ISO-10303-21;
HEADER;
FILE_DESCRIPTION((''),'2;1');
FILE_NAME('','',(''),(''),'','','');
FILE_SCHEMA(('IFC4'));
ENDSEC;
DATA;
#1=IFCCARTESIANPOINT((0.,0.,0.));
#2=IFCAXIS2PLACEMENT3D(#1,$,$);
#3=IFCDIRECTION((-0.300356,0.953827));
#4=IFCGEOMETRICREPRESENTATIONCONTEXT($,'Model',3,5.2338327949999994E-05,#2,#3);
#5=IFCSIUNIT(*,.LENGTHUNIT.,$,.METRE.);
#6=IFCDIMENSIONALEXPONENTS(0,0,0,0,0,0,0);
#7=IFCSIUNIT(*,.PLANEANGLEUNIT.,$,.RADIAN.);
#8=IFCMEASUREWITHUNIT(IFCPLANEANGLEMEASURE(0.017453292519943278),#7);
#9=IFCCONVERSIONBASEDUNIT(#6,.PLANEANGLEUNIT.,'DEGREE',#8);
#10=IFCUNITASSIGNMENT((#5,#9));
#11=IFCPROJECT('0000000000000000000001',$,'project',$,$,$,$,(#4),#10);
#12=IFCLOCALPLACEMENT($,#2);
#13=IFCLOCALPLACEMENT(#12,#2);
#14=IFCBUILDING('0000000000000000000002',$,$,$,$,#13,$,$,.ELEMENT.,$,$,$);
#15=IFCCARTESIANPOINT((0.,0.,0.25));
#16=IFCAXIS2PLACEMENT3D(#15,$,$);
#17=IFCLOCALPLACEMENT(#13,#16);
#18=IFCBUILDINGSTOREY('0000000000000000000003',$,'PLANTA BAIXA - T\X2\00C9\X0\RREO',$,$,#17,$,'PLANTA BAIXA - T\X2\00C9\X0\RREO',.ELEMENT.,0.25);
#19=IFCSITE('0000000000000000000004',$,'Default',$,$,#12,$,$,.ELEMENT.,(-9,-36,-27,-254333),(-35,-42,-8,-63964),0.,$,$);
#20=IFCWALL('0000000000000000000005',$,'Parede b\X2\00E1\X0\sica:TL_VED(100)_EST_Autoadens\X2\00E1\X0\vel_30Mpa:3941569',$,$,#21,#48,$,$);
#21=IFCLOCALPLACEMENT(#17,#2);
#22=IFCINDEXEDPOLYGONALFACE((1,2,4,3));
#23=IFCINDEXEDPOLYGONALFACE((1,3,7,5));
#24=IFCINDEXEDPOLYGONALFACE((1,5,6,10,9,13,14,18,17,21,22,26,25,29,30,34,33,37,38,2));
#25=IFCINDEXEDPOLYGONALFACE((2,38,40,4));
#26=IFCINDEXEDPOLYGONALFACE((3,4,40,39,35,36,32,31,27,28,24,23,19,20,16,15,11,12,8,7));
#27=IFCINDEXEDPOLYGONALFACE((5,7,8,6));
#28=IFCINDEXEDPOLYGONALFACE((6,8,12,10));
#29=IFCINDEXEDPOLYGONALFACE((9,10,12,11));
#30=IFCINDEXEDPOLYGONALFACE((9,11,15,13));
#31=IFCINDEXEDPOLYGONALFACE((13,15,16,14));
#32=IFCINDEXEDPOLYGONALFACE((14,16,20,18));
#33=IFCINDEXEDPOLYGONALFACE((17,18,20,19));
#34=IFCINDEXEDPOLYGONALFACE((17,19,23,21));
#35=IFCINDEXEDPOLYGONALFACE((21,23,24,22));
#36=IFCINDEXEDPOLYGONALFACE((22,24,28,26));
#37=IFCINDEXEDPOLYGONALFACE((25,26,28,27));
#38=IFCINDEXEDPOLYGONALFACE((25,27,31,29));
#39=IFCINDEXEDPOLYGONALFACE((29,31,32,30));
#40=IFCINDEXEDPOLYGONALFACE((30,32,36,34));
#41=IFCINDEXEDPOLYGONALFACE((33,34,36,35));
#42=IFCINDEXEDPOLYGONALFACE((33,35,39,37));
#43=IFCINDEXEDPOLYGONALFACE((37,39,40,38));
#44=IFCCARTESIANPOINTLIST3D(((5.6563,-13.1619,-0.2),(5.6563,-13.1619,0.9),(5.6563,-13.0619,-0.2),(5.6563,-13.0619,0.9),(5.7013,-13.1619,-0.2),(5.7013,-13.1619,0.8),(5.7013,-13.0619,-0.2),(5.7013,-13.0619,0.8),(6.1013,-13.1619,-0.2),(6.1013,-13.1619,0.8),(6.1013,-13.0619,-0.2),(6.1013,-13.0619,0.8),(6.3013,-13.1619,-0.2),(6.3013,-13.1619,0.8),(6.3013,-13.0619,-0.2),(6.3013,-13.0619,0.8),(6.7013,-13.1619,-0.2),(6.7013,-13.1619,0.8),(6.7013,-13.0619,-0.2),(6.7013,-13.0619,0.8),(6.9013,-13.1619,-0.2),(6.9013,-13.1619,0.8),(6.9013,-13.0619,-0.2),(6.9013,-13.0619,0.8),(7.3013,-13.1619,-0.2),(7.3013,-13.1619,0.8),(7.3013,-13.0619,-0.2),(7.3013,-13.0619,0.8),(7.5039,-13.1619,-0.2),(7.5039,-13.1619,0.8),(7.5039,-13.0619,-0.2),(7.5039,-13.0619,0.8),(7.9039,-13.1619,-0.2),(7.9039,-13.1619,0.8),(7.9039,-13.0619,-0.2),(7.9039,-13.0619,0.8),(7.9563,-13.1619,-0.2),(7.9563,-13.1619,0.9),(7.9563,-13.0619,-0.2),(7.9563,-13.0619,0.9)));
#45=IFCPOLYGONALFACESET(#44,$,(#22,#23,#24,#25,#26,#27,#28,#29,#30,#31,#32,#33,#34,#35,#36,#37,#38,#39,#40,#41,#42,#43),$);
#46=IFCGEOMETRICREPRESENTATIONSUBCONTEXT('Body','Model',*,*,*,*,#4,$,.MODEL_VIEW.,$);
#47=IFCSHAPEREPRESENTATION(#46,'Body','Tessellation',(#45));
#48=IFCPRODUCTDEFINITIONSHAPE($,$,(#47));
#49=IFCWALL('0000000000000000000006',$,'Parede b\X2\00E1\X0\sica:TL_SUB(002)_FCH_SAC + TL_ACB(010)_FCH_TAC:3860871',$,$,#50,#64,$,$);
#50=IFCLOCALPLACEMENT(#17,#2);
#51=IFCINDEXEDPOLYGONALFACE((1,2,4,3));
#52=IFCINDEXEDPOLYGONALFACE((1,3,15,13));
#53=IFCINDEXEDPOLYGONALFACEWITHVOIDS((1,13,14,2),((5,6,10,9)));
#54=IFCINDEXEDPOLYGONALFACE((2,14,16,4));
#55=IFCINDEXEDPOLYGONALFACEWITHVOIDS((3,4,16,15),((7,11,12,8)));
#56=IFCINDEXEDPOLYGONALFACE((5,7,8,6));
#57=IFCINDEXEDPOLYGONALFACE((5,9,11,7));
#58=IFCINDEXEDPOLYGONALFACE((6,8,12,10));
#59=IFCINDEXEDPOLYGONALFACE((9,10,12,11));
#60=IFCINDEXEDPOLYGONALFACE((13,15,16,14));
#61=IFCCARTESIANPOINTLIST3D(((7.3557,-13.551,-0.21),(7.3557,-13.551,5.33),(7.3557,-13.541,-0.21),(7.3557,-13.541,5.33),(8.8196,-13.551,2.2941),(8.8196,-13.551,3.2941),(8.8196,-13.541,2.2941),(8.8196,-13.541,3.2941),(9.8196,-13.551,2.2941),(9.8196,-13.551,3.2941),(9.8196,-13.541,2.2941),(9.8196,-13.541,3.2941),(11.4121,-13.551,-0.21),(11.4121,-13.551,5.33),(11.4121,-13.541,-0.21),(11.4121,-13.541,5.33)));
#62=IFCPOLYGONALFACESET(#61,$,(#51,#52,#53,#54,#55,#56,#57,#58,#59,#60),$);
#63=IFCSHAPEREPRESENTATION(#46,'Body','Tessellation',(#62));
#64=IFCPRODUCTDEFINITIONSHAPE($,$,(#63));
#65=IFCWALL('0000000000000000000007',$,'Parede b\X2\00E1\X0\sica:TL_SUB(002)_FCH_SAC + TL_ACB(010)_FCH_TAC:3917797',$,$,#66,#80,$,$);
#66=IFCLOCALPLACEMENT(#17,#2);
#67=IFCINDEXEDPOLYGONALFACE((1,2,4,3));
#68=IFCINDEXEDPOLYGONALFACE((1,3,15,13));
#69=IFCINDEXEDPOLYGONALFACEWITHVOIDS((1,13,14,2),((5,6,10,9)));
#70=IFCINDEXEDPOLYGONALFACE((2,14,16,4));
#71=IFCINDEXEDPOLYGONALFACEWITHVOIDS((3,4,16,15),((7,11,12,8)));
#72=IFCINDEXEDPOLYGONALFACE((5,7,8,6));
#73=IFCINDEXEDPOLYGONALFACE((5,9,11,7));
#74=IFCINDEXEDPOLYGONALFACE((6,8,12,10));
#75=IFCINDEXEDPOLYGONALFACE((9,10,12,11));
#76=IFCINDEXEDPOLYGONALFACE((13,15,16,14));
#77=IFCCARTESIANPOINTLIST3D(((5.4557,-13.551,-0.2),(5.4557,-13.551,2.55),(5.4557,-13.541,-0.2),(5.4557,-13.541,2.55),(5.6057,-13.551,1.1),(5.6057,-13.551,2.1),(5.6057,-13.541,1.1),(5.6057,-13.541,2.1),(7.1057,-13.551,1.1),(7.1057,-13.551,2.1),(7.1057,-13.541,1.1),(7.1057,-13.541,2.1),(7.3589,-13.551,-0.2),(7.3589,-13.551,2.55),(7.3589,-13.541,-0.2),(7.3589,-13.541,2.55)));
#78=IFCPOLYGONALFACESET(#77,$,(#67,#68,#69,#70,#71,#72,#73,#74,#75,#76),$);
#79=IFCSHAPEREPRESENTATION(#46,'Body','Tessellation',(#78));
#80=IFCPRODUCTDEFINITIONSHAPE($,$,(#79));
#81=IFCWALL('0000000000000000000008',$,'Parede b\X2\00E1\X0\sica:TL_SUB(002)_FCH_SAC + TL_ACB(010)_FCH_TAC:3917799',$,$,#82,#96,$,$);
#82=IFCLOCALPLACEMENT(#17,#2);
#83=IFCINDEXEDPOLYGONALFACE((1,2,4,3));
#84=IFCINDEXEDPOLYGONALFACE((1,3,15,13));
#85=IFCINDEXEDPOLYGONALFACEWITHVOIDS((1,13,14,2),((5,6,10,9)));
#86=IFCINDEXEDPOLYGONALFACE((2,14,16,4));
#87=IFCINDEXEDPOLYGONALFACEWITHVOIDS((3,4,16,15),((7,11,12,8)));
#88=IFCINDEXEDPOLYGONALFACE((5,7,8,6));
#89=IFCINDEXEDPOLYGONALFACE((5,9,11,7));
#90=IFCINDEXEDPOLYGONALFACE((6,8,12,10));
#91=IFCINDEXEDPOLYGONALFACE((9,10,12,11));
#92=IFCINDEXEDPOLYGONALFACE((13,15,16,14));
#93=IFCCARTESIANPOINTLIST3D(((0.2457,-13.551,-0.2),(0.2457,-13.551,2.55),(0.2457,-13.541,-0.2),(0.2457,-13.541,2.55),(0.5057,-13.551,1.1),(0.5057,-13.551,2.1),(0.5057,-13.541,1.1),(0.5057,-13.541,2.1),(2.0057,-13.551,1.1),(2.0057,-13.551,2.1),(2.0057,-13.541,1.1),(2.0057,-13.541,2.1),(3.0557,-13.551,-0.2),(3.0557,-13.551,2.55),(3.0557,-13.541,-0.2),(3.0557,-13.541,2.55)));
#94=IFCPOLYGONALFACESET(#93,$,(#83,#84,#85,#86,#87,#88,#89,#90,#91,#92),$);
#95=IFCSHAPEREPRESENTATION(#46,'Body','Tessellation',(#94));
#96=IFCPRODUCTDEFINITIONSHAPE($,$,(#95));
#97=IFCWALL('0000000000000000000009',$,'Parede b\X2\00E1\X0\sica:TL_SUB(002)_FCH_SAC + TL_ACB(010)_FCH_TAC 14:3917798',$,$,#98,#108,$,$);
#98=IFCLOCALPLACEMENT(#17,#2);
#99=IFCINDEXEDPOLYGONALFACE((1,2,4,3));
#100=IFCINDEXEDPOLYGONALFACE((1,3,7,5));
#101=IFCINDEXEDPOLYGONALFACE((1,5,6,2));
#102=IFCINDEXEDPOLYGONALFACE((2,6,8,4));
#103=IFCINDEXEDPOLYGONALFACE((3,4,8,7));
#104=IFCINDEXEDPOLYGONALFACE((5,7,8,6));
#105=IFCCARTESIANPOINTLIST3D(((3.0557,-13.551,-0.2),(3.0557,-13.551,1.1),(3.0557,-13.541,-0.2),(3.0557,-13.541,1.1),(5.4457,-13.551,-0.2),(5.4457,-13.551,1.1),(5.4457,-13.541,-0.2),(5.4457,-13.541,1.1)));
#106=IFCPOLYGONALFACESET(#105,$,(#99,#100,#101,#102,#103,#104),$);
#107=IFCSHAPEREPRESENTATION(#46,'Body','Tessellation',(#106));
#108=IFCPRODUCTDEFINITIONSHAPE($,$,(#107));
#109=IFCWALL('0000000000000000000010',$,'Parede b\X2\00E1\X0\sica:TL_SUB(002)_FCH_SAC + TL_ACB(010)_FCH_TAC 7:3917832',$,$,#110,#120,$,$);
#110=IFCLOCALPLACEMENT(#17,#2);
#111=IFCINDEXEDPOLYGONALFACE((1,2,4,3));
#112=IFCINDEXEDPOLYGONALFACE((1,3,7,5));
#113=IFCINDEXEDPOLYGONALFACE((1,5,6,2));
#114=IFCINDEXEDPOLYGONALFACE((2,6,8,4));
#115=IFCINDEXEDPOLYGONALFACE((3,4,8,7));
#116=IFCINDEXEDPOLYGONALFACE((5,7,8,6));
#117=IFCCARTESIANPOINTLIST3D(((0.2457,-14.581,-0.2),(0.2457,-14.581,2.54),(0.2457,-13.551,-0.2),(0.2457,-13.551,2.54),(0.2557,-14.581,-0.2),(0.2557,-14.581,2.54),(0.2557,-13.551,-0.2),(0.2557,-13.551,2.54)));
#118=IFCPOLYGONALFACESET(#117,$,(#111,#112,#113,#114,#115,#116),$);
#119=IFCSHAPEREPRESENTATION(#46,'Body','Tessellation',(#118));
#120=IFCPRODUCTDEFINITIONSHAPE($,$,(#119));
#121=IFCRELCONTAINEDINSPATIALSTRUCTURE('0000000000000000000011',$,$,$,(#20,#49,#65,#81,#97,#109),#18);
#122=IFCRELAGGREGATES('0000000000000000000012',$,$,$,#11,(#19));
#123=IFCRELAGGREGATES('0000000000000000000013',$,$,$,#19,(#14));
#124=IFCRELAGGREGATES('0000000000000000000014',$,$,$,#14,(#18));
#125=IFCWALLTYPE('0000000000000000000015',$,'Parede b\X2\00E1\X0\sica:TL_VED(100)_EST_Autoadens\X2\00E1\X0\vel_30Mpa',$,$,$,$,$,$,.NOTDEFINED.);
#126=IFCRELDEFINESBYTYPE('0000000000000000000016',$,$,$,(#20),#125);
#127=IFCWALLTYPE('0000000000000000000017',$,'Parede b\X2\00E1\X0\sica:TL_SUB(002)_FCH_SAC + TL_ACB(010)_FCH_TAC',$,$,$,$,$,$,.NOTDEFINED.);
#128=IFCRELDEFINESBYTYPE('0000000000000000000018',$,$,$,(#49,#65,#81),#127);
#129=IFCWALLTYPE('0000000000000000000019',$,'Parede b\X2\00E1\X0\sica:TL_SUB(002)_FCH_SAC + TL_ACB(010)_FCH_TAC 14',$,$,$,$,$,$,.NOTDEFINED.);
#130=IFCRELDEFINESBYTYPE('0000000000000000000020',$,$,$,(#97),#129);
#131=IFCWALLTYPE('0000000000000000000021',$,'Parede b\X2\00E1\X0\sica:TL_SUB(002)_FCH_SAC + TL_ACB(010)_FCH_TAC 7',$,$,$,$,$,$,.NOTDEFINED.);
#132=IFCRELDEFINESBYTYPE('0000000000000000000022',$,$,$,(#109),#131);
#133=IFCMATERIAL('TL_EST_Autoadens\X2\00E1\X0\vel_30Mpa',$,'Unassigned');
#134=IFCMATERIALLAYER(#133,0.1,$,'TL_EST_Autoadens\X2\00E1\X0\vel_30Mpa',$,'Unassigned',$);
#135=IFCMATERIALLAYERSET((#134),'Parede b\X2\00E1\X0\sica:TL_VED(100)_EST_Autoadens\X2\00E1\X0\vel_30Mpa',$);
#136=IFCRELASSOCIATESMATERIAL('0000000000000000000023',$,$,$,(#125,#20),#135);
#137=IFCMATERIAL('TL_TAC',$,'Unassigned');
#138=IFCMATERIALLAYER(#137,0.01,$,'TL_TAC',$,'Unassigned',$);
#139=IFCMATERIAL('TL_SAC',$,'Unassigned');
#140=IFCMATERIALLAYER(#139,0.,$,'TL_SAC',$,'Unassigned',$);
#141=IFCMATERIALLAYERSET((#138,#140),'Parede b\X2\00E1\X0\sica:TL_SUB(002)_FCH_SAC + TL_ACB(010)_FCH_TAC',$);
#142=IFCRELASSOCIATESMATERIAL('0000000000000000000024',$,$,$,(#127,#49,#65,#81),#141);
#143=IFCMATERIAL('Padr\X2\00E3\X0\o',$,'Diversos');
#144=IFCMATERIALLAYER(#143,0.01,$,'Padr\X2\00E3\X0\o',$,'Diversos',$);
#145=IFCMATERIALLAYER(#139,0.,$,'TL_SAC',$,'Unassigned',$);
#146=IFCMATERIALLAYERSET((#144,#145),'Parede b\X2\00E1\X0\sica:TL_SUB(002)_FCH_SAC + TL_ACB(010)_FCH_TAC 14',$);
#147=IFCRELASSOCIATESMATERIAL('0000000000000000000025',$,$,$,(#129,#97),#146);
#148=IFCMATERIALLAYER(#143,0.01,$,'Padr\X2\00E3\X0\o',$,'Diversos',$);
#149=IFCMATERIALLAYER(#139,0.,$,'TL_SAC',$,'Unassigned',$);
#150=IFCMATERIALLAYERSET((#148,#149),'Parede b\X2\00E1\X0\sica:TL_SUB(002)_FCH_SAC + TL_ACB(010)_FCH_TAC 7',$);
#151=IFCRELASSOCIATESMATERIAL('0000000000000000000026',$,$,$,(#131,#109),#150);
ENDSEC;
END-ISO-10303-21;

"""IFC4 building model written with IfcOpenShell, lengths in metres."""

from ifc_helpers import new_model, entity, si_unit, converted_unit, direction, frame, frame_2d, origin, place, context, subcontext, project, spatial, polyline, rectangle, extrude, clip, bounded_halfspace, material, layer, layer_set, layer_usage, type_object, element, save


model = new_model("IFC4")

# Units and contexts
model_context = context("Model", 3, precision=5.2338327949999994e-05, world=origin(), true_north=direction((-0.300356, 0.953827)))
body_context = subcontext(model_context, "Body", "Model", "MODEL_VIEW")
ifc_project = project(units=[si_unit("LENGTHUNIT", "METRE"), converted_unit("PLANEANGLEUNIT", "DEGREE", entity("IfcPlaneAngleMeasure", 0.017453292519943278), si_unit("PLANEANGLEUNIT", "RADIAN"), dimensions=[0, 0, 0, 0, 0, 0, 0])], contexts=[model_context])

# Site, building, storey
site_placement = place(None, origin())
site = spatial("IfcSite", under=ifc_project, at=site_placement, Name="Default", CompositionType="ELEMENT", RefLatitude=(-9, -36, -27, -254333), RefLongitude=(-35, -42, -8, -63964), RefElevation=0.0)
building_placement = place(site_placement, origin())
building = spatial("IfcBuilding", under=site, at=building_placement, CompositionType="ELEMENT")
storey_placement = place(building_placement, frame((0.0, 0.0, 0.25)))
storey = spatial("IfcBuildingStorey", under=building, at=storey_placement, Name="PLANTA BAIXA - TÉRREO", LongName="PLANTA BAIXA - TÉRREO", CompositionType="ELEMENT", Elevation=0.25)

# Shared definitions
ifc_material_1 = material(Name="TL_EST_Autoadensável_30Mpa", Category="Unassigned")
ifc_layer_1 = layer(ifc_material_1, 0.1, Name="TL_EST_Autoadensável_30Mpa", Category="Unassigned")
ifc_layer_set_1 = layer_set([ifc_layer_1], Name="Parede básica:TL_VED(100)_EST_Autoadensável_30Mpa")
wall_type_1 = type_object("IfcWallType", Name="Parede básica:TL_VED(100)_EST_Autoadensável_30Mpa", PredefinedType="NOTDEFINED", material=ifc_layer_set_1)

# Wall, openings
ifc_layer_usage_1 = layer_usage(ifc_layer_set_1, "AXIS2", "NEGATIVE", 0.05)
wall_1_placement = place(storey_placement, frame((5.6563, -13.1119, -0.2)))
wall_1 = element("IfcWall", 1, at=wall_1_placement, inside=storey, type_object=wall_type_1, material=ifc_layer_usage_1, Name="Parede básica:TL_VED(100)_EST_Autoadensável_30Mpa:3941569", context=body_context, shape_type="Clipping", body=[
    clip(extrude(rectangle(XDim=2.3, YDim=0.1, at=frame_2d((1.15, 0.0), x_axis=(-1.0, 0.0))), origin(), (0.0, 0.0, 1.0), 1.1), bounded_halfspace(frame((0.0, -0.05, 1.1), z_axis=(0.0, 0.0, -1.0), x_axis=(0.0, -1.0, 0.0)), True, frame((0.0, -0.05, 1.1)), polyline([(0.0, 0.0), (0.5, 0.0), (0.6, 0.0), (1.1, 0.0), (1.2, 0.0), (1.7027, 0.0), (1.8027, 0.0), (2.3, 0.0), (2.3, 0.05), (2.3, 0.1), (0.0, 0.1), (0.0, 0.0)]))),
])
opening_1_placement = place(wall_1_placement, frame((-5.6563, 13.1119, 0.0)))
element("IfcOpeningElement", 2, at=opening_1_placement, cuts=wall_1, PredefinedType="OPENING", context=body_context, shape_type="SweptSolid", body=[
    extrude(rectangle(XDim=1.0, YDim=0.4, at=frame_2d((0.0, 0.0), x_axis=(0.0, 1.0))), frame((7.7039, -13.8965, 0.5), z_axis=(0.0, 1.0, 0.0), x_axis=(1.0, 0.0, 0.0)), (0.0, 0.0, 1.0), 1.542),
])
opening_2_placement = place(wall_1_placement, frame((-5.6563, 13.1119, 0.0)))
element("IfcOpeningElement", 3, at=opening_2_placement, cuts=wall_1, PredefinedType="OPENING", context=body_context, shape_type="SweptSolid", body=[
    extrude(rectangle(XDim=1.0, YDim=0.4, at=frame_2d((0.0, 0.0), x_axis=(0.0, 1.0))), frame((7.1013, -13.8965, 0.5), z_axis=(0.0, 1.0, 0.0), x_axis=(1.0, 0.0, 0.0)), (0.0, 0.0, 1.0), 1.542),
])
opening_3_placement = place(wall_1_placement, frame((-5.6563, 13.1119, 0.0)))
element("IfcOpeningElement", 4, at=opening_3_placement, cuts=wall_1, PredefinedType="OPENING", context=body_context, shape_type="SweptSolid", body=[
    extrude(rectangle(XDim=1.0, YDim=0.4, at=frame_2d((0.0, 0.0), x_axis=(0.0, 1.0))), frame((6.5013, -13.8965, 0.5), z_axis=(0.0, 1.0, 0.0), x_axis=(1.0, 0.0, 0.0)), (0.0, 0.0, 1.0), 1.542),
])
opening_4_placement = place(wall_1_placement, frame((-5.6563, 13.1119, 0.0)))
element("IfcOpeningElement", 5, at=opening_4_placement, cuts=wall_1, PredefinedType="OPENING", context=body_context, shape_type="SweptSolid", body=[
    extrude(rectangle(XDim=1.0, YDim=0.4, at=frame_2d((0.0, 0.0), x_axis=(0.0, 1.0))), frame((5.9013, -13.8965, 0.5), z_axis=(0.0, 1.0, 0.0), x_axis=(1.0, 0.0, 0.0)), (0.0, 0.0, 1.0), 1.542),
])

# Walls, openings
ifc_material_2 = material(Name="TL_TAC", Category="Unassigned")
ifc_layer_2 = layer(ifc_material_2, 0.01, Name="TL_TAC", Category="Unassigned")
ifc_material_3 = material(Name="TL_SAC", Category="Unassigned")
ifc_layer_3 = layer(ifc_material_3, 0.0, Name="TL_SAC", Category="Unassigned")
ifc_layer_set_2 = layer_set([ifc_layer_2, ifc_layer_3], Name="Parede básica:TL_SUB(002)_FCH_SAC + TL_ACB(010)_FCH_TAC")
ifc_layer_usage_2 = layer_usage(ifc_layer_set_2, "AXIS2", "POSITIVE", -0.005)
wall_type_2 = type_object("IfcWallType", Name="Parede básica:TL_SUB(002)_FCH_SAC + TL_ACB(010)_FCH_TAC", PredefinedType="NOTDEFINED", material=ifc_layer_set_2)
wall_2_placement = place(storey_placement, frame((7.3557, -13.546, -0.21)))
wall_2 = element("IfcWall", 6, at=wall_2_placement, inside=storey, type_object=wall_type_2, material=ifc_layer_usage_2, Name="Parede básica:TL_SUB(002)_FCH_SAC + TL_ACB(010)_FCH_TAC:3860871", context=body_context, shape_type="SweptSolid", body=[
    extrude(rectangle(XDim=4.0564, YDim=0.01, at=frame_2d((2.0282, 0.0), x_axis=(-1.0, 0.0))), origin(), (0.0, 0.0, 1.0), 5.54),
])
opening_5_placement = place(wall_2_placement, frame((-7.3557, 13.546, 2.5041)))
element("IfcOpeningElement", 7, at=opening_5_placement, cuts=wall_2, PredefinedType="OPENING", context=body_context, shape_type="SweptSolid", body=[
    extrude(rectangle(XDim=1.0, YDim=1.0, at=frame_2d((0.0, 0.0), x_axis=(0.0, 1.0))), frame((9.3196, -15.1748, 0.5), z_axis=(0.0, 1.0, 0.0), x_axis=(1.0, 0.0, 0.0)), (0.0, 0.0, 1.0), 3.048),
])
ifc_layer_usage_3 = layer_usage(ifc_layer_set_2, "AXIS2", "NEGATIVE", 0.005)
wall_3_placement = place(storey_placement, frame((7.3589, -13.546, -0.2), z_axis=(0.0, 0.0, 1.0), x_axis=(-1.0, 0.0, 0.0)))
wall_3 = element("IfcWall", 8, at=wall_3_placement, inside=storey, type_object=wall_type_2, material=ifc_layer_usage_3, Name="Parede básica:TL_SUB(002)_FCH_SAC + TL_ACB(010)_FCH_TAC:3917797", context=body_context, shape_type="SweptSolid", body=[
    extrude(rectangle(XDim=1.9032, YDim=0.01, at=frame_2d((0.9516, 0.0), x_axis=(-1.0, 0.0))), origin(), (0.0, 0.0, 1.0), 2.75),
])
opening_6_placement = place(wall_3_placement, frame((7.3589, -13.546, 1.3)))
element("IfcOpeningElement", 9, at=opening_6_placement, cuts=wall_3, PredefinedType="OPENING", context=body_context, shape_type="SweptSolid", body=[
    extrude(rectangle(XDim=1.0, YDim=1.5, at=frame_2d((0.0, 0.0), x_axis=(0.0, 1.0))), frame((-6.3557, 12.127, 0.5), z_axis=(0.0, 1.0, 0.0), x_axis=(1.0, 0.0, 0.0)), (0.0, 0.0, 1.0), 3.048),
])
ifc_layer_usage_4 = layer_usage(ifc_layer_set_2, "AXIS2", "POSITIVE", -0.005)
wall_4_placement = place(storey_placement, frame((3.0557, -13.546, -0.2), z_axis=(0.0, 0.0, 1.0), x_axis=(-1.0, 0.0, 0.0)))
wall_4 = element("IfcWall", 10, at=wall_4_placement, inside=storey, type_object=wall_type_2, material=ifc_layer_usage_4, Name="Parede básica:TL_SUB(002)_FCH_SAC + TL_ACB(010)_FCH_TAC:3917799", context=body_context, shape_type="SweptSolid", body=[
    extrude(rectangle(XDim=2.81, YDim=0.01, at=frame_2d((1.405, 0.0), x_axis=(-1.0, 0.0))), origin(), (0.0, 0.0, 1.0), 2.75),
])
opening_7_placement = place(wall_4_placement, frame((3.0557, -13.546, 1.3)))
element("IfcOpeningElement", 11, at=opening_7_placement, cuts=wall_4, PredefinedType="OPENING", context=body_context, shape_type="SweptSolid", body=[
    extrude(rectangle(XDim=1.0, YDim=1.5, at=frame_2d((0.0, 0.0), x_axis=(0.0, 1.0))), frame((-1.2557, 12.127, 0.5), z_axis=(0.0, 1.0, 0.0), x_axis=(1.0, 0.0, 0.0)), (0.0, 0.0, 1.0), 3.048),
])

# Walls
ifc_material_4 = material(Name="Padrão", Category="Diversos")
ifc_layer_4 = layer(ifc_material_4, 0.01, Name="Padrão", Category="Diversos")
ifc_layer_5 = layer(ifc_material_3, 0.0, Name="TL_SAC", Category="Unassigned")
ifc_layer_set_3 = layer_set([ifc_layer_4, ifc_layer_5], Name="Parede básica:TL_SUB(002)_FCH_SAC + TL_ACB(010)_FCH_TAC 14")
ifc_layer_usage_5 = layer_usage(ifc_layer_set_3, "AXIS2", "NEGATIVE", 0.005)
wall_type_3 = type_object("IfcWallType", Name="Parede básica:TL_SUB(002)_FCH_SAC + TL_ACB(010)_FCH_TAC 14", PredefinedType="NOTDEFINED", material=ifc_layer_set_3)
wall_5_placement = place(storey_placement, frame((5.4457, -13.546, -0.2), z_axis=(0.0, 0.0, 1.0), x_axis=(-1.0, 0.0, 0.0)))
element("IfcWall", 12, at=wall_5_placement, inside=storey, type_object=wall_type_3, material=ifc_layer_usage_5, Name="Parede básica:TL_SUB(002)_FCH_SAC + TL_ACB(010)_FCH_TAC 14:3917798", context=body_context, shape_type="SweptSolid", body=[
    extrude(rectangle(XDim=2.39, YDim=0.01, at=frame_2d((1.195, 0.0), x_axis=(-1.0, 0.0))), origin(), (0.0, 0.0, 1.0), 1.3),
])
ifc_layer_6 = layer(ifc_material_4, 0.01, Name="Padrão", Category="Diversos")
ifc_layer_7 = layer(ifc_material_3, 0.0, Name="TL_SAC", Category="Unassigned")
ifc_layer_set_4 = layer_set([ifc_layer_6, ifc_layer_7], Name="Parede básica:TL_SUB(002)_FCH_SAC + TL_ACB(010)_FCH_TAC 7")
ifc_layer_usage_6 = layer_usage(ifc_layer_set_4, "AXIS2", "NEGATIVE", 0.005)
wall_type_4 = type_object("IfcWallType", Name="Parede básica:TL_SUB(002)_FCH_SAC + TL_ACB(010)_FCH_TAC 7", PredefinedType="NOTDEFINED", material=ifc_layer_set_4)
wall_6_placement = place(storey_placement, frame((0.2507, -13.551, -0.2), z_axis=(0.0, 0.0, 1.0), x_axis=(0.0, -1.0, 0.0)))
element("IfcWall", 13, at=wall_6_placement, inside=storey, type_object=wall_type_4, material=ifc_layer_usage_6, Name="Parede básica:TL_SUB(002)_FCH_SAC + TL_ACB(010)_FCH_TAC 7:3917832", context=body_context, shape_type="SweptSolid", body=[
    extrude(rectangle(XDim=1.03, YDim=0.01, at=frame_2d((0.515, 0.0), x_axis=(-1.0, 0.0))), origin(), (0.0, 0.0, 1.0), 2.74),
])

save(model, "model.ifc")
